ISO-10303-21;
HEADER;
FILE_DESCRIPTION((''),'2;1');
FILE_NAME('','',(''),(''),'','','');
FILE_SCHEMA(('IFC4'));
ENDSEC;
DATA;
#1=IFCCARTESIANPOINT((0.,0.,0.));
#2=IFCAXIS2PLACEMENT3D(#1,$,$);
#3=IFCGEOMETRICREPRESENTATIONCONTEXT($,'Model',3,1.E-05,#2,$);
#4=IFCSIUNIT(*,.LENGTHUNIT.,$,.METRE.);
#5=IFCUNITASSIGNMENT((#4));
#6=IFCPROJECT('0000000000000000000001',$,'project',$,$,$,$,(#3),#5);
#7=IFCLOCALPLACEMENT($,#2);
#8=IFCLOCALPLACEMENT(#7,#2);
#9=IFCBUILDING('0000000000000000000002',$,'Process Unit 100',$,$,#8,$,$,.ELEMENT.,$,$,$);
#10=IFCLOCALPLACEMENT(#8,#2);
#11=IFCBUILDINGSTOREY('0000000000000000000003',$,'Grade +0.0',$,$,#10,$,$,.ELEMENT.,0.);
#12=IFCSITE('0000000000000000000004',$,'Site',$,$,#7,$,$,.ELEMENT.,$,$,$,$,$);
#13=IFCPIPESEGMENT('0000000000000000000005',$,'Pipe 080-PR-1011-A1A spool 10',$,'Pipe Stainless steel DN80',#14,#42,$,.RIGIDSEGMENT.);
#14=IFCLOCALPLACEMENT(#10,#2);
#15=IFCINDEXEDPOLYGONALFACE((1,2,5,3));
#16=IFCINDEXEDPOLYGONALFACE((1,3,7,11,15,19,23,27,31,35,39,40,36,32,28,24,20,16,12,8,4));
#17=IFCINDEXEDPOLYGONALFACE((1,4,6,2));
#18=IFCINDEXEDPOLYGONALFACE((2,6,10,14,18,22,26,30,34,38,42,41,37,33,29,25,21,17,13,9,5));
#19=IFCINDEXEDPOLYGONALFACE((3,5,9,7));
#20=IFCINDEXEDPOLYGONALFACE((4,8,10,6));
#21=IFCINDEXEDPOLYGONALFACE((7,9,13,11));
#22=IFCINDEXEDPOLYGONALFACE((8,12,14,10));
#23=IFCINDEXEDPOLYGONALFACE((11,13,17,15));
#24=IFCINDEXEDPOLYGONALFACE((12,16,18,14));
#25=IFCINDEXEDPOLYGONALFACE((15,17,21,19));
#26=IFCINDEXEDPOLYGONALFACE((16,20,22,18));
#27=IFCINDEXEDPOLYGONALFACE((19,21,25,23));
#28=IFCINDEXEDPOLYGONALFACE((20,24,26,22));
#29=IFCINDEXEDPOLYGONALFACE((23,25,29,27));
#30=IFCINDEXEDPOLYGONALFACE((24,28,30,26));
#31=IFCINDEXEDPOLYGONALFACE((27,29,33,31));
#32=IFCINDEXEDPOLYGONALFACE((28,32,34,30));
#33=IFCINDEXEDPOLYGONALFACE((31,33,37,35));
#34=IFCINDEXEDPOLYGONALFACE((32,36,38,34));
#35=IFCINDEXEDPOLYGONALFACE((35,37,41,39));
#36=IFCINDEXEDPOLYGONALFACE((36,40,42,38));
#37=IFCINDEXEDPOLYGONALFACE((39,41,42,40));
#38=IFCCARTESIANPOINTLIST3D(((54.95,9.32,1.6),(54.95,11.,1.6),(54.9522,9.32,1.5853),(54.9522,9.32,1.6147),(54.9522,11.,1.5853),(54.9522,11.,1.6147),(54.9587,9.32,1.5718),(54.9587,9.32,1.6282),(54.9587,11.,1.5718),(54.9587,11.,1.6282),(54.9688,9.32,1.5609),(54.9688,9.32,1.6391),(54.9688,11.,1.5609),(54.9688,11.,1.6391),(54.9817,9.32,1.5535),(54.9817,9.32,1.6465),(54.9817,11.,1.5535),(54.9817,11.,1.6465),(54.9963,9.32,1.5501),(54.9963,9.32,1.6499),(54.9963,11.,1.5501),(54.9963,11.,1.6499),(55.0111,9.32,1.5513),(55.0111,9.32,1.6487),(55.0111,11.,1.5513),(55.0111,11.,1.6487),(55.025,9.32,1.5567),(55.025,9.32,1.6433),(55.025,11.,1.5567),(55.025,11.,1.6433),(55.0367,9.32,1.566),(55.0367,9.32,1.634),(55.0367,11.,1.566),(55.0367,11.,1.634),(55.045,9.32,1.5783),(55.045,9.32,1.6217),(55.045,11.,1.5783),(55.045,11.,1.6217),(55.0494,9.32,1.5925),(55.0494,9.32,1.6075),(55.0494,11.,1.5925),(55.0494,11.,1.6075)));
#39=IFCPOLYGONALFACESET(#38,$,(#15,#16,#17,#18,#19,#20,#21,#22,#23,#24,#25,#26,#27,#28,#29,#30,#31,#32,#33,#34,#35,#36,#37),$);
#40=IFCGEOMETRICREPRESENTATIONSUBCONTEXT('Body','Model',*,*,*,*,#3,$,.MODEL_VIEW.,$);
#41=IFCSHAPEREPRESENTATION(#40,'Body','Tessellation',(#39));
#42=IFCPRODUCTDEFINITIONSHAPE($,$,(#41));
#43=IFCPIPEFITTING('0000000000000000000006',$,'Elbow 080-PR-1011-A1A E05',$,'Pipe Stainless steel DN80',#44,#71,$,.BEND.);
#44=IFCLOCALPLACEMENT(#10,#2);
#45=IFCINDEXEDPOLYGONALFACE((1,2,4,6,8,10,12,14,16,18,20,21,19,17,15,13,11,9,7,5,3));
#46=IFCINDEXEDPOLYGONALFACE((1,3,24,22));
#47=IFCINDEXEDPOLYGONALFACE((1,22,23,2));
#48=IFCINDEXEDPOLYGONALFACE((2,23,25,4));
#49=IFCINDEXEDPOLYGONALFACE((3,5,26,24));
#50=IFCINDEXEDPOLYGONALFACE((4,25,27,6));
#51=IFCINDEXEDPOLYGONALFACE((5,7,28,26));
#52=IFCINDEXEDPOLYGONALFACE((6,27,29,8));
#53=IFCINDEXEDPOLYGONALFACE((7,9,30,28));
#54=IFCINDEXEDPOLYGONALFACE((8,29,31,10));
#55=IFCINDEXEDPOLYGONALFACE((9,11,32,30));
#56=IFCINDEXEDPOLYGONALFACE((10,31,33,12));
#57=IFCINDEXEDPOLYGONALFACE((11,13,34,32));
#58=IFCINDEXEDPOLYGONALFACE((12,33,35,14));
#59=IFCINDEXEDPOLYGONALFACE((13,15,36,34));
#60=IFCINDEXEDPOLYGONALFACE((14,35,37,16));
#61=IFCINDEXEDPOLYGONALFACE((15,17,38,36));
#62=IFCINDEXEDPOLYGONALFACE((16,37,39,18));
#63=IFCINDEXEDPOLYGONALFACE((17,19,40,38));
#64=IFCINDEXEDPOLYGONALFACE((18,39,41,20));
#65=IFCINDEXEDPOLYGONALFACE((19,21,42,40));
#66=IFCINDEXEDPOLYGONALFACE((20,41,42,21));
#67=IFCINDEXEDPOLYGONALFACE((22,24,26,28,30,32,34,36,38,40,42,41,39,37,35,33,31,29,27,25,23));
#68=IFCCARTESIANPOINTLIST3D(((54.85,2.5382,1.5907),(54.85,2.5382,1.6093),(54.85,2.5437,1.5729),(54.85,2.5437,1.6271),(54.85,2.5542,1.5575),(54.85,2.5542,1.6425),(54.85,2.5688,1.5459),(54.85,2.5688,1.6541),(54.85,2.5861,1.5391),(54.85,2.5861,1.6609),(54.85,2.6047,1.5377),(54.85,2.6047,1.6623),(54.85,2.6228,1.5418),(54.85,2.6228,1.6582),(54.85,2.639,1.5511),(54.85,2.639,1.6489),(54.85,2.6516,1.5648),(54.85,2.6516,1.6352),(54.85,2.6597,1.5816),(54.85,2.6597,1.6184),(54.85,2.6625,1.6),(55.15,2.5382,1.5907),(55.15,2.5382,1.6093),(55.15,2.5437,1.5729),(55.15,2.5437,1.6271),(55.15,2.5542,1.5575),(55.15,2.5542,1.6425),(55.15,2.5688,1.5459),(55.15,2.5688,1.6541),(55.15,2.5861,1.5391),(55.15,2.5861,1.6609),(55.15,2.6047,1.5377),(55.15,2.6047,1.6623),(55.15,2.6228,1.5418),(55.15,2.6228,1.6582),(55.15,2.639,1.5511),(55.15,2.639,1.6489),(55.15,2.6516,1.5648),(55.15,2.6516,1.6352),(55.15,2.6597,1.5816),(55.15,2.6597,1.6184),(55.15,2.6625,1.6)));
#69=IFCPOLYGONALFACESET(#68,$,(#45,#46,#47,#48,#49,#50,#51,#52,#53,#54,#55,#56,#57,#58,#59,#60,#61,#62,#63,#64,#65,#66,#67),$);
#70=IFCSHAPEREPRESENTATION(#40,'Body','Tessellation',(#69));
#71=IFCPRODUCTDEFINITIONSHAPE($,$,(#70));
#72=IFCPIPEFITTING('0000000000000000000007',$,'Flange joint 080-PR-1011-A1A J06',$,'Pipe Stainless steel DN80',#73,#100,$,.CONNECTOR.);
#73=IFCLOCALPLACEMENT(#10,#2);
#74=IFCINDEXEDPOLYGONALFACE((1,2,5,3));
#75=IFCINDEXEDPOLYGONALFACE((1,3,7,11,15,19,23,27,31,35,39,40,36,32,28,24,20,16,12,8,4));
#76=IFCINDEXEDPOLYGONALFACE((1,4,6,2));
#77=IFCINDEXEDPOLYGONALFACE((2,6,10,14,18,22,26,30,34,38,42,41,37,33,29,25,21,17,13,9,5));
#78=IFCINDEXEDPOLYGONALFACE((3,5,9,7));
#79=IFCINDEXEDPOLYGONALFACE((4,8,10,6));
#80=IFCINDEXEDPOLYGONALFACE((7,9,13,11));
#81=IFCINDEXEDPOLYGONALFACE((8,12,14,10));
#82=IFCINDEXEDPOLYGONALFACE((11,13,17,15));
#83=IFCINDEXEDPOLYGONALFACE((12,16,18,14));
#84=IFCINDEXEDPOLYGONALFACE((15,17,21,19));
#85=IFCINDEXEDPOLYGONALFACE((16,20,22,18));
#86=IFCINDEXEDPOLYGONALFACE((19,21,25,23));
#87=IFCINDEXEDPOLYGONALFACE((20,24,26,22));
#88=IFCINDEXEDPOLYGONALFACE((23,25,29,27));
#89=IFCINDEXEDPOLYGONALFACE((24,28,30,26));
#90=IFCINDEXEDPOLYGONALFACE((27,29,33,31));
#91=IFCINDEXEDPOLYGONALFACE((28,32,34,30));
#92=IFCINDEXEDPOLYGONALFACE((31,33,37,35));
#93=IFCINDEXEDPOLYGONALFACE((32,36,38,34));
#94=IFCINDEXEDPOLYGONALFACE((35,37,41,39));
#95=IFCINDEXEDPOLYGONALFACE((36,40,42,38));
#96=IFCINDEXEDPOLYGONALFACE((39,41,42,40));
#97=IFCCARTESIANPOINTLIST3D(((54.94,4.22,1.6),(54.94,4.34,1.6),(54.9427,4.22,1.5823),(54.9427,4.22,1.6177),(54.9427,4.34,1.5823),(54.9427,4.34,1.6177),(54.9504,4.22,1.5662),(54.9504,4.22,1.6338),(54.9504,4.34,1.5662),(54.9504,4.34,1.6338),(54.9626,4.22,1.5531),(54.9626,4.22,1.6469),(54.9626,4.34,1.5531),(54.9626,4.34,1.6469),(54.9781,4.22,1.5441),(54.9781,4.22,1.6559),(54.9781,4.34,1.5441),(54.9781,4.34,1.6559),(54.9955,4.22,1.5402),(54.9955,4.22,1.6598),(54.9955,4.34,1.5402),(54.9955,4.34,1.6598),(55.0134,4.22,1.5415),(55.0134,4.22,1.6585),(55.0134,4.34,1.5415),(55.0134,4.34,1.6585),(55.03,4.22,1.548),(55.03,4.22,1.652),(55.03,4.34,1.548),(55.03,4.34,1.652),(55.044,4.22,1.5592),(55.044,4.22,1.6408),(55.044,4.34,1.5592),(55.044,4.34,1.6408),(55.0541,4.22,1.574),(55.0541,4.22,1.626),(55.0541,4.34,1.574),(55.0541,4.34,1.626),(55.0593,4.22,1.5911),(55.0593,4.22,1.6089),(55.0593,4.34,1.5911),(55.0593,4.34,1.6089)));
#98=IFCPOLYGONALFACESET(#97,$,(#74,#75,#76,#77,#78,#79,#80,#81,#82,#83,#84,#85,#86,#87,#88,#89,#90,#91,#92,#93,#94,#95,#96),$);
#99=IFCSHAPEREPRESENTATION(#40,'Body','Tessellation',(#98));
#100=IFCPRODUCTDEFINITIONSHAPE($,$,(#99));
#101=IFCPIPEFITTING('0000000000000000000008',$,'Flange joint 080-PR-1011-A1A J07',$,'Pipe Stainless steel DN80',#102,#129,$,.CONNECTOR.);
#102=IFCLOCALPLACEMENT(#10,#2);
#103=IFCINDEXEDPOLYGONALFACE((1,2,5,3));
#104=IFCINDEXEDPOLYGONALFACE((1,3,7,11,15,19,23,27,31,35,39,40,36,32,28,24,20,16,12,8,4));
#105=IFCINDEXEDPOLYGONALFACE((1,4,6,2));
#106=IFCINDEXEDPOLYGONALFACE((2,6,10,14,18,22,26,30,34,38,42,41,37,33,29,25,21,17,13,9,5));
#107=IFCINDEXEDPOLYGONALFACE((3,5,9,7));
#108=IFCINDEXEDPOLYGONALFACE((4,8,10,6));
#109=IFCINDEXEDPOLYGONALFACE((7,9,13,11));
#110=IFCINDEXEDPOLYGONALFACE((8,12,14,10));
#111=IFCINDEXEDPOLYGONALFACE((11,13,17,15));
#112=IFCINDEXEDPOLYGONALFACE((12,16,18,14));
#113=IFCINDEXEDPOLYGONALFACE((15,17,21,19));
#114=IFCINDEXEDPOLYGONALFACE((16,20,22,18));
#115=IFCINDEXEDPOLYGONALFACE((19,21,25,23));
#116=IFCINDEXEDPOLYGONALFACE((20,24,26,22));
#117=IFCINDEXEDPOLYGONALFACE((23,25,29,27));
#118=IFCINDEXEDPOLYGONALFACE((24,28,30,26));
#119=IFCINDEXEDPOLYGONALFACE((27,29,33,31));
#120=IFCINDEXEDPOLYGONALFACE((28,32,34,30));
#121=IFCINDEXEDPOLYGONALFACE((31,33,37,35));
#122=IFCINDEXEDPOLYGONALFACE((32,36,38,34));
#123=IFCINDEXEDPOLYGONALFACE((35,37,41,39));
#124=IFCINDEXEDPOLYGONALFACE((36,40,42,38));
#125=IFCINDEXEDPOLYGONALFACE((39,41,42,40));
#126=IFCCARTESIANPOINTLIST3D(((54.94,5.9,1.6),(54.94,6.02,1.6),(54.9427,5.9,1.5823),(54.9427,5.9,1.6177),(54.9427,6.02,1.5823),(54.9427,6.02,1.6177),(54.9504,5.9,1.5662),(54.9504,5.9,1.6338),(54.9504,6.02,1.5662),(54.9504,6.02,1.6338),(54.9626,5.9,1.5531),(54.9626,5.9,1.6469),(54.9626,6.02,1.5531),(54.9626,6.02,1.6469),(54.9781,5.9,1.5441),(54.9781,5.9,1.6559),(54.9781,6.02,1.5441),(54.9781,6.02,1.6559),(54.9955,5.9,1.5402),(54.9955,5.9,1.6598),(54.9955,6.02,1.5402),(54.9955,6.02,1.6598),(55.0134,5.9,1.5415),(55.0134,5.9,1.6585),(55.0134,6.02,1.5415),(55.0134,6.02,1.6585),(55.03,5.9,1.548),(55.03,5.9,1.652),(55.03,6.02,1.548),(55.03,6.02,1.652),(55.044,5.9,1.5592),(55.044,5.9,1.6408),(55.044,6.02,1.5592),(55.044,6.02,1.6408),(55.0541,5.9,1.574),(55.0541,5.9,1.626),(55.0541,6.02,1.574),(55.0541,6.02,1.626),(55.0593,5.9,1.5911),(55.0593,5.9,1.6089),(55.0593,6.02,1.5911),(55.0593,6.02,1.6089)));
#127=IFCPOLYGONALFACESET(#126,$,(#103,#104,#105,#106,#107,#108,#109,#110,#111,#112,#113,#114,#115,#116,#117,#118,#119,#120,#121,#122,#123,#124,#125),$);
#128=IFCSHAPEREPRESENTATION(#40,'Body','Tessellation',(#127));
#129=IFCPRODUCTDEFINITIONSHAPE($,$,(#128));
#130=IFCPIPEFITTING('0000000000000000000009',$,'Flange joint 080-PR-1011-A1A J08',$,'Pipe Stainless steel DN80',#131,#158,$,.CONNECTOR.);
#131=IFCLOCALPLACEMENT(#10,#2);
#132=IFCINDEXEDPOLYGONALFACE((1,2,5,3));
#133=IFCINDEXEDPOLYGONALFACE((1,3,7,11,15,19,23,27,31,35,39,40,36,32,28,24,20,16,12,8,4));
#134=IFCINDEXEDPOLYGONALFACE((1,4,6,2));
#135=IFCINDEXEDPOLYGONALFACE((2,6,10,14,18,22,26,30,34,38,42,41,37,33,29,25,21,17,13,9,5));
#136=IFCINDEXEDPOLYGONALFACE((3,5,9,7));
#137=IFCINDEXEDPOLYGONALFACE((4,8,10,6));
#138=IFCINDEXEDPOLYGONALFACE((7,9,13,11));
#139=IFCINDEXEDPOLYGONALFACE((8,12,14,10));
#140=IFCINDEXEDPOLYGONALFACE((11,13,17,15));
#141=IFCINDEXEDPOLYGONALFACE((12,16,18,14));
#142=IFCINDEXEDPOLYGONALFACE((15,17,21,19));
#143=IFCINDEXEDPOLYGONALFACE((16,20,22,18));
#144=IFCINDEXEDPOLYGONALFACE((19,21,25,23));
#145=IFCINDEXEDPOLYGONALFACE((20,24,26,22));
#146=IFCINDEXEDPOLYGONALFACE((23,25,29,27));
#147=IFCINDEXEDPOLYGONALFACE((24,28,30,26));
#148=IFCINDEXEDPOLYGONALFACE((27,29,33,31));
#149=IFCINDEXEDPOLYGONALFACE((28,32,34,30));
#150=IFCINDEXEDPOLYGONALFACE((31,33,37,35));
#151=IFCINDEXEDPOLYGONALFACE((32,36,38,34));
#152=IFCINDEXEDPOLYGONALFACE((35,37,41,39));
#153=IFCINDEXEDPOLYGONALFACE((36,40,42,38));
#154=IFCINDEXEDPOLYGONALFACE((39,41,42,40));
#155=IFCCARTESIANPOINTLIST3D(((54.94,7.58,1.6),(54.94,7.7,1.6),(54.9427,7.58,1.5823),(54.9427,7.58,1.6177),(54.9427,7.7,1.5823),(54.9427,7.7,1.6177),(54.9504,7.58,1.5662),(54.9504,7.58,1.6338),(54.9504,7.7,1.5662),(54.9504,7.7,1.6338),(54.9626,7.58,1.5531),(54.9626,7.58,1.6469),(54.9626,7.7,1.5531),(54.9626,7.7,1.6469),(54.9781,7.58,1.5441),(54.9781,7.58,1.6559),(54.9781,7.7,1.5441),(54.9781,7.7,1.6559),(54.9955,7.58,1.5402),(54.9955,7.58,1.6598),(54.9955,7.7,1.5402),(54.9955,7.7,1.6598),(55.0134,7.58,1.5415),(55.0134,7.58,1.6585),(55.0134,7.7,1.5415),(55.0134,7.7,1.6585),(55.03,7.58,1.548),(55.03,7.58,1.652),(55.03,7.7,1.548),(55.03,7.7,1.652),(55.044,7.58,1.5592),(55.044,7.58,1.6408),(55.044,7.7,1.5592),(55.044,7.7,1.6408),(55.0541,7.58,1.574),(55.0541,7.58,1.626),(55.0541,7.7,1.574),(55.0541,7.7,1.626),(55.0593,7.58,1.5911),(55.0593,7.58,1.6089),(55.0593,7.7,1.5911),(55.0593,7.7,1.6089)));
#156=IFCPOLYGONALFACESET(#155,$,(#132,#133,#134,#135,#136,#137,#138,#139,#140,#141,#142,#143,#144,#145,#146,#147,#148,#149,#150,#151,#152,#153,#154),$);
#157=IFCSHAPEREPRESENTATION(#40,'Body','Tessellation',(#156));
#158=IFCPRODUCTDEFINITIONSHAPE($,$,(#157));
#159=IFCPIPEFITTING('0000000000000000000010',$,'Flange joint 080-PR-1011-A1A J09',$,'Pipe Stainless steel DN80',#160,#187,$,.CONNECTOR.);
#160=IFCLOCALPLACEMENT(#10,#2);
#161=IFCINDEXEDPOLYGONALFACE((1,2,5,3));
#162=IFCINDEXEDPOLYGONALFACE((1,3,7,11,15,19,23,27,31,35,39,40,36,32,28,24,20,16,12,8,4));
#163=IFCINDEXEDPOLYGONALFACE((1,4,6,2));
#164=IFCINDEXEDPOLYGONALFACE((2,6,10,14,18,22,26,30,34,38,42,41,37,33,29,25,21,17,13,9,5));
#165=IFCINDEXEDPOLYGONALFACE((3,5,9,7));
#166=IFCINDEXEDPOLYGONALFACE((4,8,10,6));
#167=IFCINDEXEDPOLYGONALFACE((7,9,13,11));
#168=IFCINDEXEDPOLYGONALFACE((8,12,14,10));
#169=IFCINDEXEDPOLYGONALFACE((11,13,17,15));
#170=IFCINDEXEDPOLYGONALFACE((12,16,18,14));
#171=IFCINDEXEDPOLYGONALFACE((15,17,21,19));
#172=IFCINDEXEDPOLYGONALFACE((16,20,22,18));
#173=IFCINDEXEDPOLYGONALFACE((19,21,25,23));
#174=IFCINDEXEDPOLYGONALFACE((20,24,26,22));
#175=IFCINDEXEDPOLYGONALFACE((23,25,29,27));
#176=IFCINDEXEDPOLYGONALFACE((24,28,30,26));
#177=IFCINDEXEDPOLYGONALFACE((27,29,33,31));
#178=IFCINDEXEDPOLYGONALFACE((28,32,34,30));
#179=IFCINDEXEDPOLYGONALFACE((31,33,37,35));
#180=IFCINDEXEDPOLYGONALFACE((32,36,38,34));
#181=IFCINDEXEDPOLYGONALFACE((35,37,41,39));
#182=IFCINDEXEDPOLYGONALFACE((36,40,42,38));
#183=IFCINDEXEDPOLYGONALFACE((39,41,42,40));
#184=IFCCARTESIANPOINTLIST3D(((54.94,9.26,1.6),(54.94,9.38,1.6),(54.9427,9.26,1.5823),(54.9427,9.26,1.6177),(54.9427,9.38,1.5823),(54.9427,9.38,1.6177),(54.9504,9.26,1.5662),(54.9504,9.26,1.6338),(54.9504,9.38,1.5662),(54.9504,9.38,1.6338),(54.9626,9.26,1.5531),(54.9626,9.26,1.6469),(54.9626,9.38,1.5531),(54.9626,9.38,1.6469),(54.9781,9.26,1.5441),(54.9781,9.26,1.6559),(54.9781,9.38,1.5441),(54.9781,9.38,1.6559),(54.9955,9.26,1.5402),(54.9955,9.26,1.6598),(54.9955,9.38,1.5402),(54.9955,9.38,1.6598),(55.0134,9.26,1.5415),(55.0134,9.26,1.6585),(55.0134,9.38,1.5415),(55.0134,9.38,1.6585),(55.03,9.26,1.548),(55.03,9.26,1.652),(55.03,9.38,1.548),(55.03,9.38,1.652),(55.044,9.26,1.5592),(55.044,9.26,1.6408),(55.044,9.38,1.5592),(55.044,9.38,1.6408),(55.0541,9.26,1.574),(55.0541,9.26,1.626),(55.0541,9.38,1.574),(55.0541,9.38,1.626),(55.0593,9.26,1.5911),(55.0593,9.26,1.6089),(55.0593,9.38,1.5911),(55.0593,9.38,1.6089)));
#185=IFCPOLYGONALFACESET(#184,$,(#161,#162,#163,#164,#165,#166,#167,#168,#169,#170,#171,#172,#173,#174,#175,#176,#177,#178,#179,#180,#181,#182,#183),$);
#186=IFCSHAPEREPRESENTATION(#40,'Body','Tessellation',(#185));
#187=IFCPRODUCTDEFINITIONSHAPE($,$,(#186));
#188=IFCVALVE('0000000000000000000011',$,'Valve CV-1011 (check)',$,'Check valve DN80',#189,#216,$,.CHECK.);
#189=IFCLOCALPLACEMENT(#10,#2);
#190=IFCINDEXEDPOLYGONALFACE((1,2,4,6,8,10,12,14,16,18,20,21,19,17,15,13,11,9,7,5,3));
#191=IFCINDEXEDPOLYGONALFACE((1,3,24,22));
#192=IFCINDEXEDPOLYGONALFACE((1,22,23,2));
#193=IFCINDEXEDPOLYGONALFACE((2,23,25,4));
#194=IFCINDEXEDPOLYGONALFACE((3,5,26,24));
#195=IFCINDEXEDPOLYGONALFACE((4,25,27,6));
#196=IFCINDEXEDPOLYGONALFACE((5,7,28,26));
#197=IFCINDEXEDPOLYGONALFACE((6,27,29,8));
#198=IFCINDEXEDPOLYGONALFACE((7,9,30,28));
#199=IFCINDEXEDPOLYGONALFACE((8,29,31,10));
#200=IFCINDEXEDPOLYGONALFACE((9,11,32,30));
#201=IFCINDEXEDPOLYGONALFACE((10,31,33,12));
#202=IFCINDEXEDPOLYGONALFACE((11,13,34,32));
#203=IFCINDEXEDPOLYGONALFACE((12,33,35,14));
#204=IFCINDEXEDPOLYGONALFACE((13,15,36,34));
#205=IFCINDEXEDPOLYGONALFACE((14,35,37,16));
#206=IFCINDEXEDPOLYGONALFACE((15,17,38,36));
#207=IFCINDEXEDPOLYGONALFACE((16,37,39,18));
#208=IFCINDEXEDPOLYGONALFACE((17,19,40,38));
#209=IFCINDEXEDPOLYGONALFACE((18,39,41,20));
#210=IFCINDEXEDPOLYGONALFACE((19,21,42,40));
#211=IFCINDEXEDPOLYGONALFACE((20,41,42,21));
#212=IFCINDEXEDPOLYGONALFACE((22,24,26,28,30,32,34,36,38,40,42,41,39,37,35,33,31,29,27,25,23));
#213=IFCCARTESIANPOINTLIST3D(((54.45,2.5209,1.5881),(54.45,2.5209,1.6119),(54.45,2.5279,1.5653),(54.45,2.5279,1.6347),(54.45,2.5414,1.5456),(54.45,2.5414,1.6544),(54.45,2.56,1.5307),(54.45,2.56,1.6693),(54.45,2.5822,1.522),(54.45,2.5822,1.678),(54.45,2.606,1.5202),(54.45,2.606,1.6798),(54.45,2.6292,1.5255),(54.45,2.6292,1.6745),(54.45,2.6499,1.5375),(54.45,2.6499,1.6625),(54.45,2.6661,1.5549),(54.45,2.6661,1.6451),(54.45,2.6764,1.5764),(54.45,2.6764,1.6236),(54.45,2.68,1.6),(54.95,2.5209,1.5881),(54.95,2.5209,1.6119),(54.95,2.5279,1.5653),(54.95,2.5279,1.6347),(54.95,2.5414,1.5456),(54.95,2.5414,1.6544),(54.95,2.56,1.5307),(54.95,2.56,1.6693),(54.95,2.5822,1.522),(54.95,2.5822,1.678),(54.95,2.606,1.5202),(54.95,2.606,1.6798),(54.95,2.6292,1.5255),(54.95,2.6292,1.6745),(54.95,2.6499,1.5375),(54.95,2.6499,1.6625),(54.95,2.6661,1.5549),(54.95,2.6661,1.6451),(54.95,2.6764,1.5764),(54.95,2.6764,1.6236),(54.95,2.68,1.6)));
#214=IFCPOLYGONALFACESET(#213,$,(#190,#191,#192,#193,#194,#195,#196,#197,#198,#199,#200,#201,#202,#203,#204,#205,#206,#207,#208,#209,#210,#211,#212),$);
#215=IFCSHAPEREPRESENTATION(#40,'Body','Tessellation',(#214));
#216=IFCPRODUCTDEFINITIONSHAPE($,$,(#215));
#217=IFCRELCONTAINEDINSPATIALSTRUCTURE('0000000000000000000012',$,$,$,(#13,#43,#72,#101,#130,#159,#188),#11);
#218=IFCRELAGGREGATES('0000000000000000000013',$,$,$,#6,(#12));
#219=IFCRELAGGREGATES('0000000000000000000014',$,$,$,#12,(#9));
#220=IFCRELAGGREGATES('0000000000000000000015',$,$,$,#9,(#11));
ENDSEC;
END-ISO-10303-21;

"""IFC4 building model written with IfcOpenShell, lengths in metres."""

from ifc_helpers import new_model, si_unit, frame, origin, place, context, subcontext, project, spatial, circle, extrude, element, save


model = new_model("IFC4")

# Units and contexts
model_context = context("Model", 3, precision=1e-05, world=origin())
body_context = subcontext(model_context, "Body", "Model", "MODEL_VIEW")
ifc_project = project(units=[si_unit("LENGTHUNIT", "METRE")], contexts=[model_context])

# Site, building, storey
site_placement = place(None, origin())
site = spatial("IfcSite", under=ifc_project, at=site_placement, Name="Site", CompositionType="ELEMENT")
building_placement = place(site_placement, origin())
building = spatial("IfcBuilding", under=site, at=building_placement, Name="Process Unit 100", CompositionType="ELEMENT")
storey_placement = place(building_placement, origin())
storey = spatial("IfcBuildingStorey", under=building, at=storey_placement, Name="Grade +0.0", CompositionType="ELEMENT", Elevation=0.0)

# Pipe segment
for number, where, z_axis, x_axis, name in (
    (1, (55.0, 9.32, 1.6), (0.0, 1.0, 0.0), (-1.0, 0.0, 0.0), "Pipe 080-PR-1011-A1A spool 10"),
):
    element("IfcPipeSegment", number, at=place(storey_placement, frame(where, z_axis=z_axis, x_axis=x_axis)), inside=storey, Name=name, ObjectType="Pipe Stainless steel DN80", PredefinedType="RIGIDSEGMENT", context=body_context, shape_type="SweptSolid", body=[
        extrude(circle(Radius=0.05), origin(), (0.0, 0.0, 1.0), 1.68),
    ])

# Pipe fittings
pipe_fitting_1_placement = place(storey_placement, frame((54.85, 2.6, 1.6), z_axis=(1.0, 0.0, 0.0), x_axis=(0.0, 1.0, 0.0)))
element("IfcPipeFitting", 2, at=pipe_fitting_1_placement, inside=storey, Name="Elbow 080-PR-1011-A1A E05", ObjectType="Pipe Stainless steel DN80", PredefinedType="BEND", context=body_context, shape_type="SweptSolid", body=[
    extrude(circle(Radius=0.0625), origin(), (0.0, 0.0, 1.0), 0.3),
])
for number, where, z_axis, x_axis, name in (
    (3, (55.0, 4.22, 1.6), (0.0, 1.0, 0.0), (-1.0, 0.0, 0.0), "Flange joint 080-PR-1011-A1A J06"),
    (4, (55.0, 5.9, 1.6), (0.0, 1.0, 0.0), (-1.0, 0.0, 0.0), "Flange joint 080-PR-1011-A1A J07"),
    (5, (55.0, 7.58, 1.6), (0.0, 1.0, 0.0), (-1.0, 0.0, 0.0), "Flange joint 080-PR-1011-A1A J08"),
    (6, (55.0, 9.26, 1.6), (0.0, 1.0, 0.0), (-1.0, 0.0, 0.0), "Flange joint 080-PR-1011-A1A J09"),
):
    element("IfcPipeFitting", number, at=place(storey_placement, frame(where, z_axis=z_axis, x_axis=x_axis)), inside=storey, Name=name, ObjectType="Pipe Stainless steel DN80", PredefinedType="CONNECTOR", context=body_context, shape_type="SweptSolid", body=[
        extrude(circle(Radius=0.06), origin(), (0.0, 0.0, 1.0), 0.12),
    ])

# Valve
valve_1_placement = place(storey_placement, frame((54.45, 2.6, 1.6), z_axis=(1.0, 0.0, 0.0), x_axis=(0.0, 1.0, 0.0)))
element("IfcValve", 7, at=valve_1_placement, inside=storey, Name="Valve CV-1011 (check)", ObjectType="Check valve DN80", PredefinedType="CHECK", context=body_context, shape_type="SweptSolid", body=[
    extrude(circle(Radius=0.08), origin(), (0.0, 0.0, 1.0), 0.5),
])

save(model, "model.ifc")
